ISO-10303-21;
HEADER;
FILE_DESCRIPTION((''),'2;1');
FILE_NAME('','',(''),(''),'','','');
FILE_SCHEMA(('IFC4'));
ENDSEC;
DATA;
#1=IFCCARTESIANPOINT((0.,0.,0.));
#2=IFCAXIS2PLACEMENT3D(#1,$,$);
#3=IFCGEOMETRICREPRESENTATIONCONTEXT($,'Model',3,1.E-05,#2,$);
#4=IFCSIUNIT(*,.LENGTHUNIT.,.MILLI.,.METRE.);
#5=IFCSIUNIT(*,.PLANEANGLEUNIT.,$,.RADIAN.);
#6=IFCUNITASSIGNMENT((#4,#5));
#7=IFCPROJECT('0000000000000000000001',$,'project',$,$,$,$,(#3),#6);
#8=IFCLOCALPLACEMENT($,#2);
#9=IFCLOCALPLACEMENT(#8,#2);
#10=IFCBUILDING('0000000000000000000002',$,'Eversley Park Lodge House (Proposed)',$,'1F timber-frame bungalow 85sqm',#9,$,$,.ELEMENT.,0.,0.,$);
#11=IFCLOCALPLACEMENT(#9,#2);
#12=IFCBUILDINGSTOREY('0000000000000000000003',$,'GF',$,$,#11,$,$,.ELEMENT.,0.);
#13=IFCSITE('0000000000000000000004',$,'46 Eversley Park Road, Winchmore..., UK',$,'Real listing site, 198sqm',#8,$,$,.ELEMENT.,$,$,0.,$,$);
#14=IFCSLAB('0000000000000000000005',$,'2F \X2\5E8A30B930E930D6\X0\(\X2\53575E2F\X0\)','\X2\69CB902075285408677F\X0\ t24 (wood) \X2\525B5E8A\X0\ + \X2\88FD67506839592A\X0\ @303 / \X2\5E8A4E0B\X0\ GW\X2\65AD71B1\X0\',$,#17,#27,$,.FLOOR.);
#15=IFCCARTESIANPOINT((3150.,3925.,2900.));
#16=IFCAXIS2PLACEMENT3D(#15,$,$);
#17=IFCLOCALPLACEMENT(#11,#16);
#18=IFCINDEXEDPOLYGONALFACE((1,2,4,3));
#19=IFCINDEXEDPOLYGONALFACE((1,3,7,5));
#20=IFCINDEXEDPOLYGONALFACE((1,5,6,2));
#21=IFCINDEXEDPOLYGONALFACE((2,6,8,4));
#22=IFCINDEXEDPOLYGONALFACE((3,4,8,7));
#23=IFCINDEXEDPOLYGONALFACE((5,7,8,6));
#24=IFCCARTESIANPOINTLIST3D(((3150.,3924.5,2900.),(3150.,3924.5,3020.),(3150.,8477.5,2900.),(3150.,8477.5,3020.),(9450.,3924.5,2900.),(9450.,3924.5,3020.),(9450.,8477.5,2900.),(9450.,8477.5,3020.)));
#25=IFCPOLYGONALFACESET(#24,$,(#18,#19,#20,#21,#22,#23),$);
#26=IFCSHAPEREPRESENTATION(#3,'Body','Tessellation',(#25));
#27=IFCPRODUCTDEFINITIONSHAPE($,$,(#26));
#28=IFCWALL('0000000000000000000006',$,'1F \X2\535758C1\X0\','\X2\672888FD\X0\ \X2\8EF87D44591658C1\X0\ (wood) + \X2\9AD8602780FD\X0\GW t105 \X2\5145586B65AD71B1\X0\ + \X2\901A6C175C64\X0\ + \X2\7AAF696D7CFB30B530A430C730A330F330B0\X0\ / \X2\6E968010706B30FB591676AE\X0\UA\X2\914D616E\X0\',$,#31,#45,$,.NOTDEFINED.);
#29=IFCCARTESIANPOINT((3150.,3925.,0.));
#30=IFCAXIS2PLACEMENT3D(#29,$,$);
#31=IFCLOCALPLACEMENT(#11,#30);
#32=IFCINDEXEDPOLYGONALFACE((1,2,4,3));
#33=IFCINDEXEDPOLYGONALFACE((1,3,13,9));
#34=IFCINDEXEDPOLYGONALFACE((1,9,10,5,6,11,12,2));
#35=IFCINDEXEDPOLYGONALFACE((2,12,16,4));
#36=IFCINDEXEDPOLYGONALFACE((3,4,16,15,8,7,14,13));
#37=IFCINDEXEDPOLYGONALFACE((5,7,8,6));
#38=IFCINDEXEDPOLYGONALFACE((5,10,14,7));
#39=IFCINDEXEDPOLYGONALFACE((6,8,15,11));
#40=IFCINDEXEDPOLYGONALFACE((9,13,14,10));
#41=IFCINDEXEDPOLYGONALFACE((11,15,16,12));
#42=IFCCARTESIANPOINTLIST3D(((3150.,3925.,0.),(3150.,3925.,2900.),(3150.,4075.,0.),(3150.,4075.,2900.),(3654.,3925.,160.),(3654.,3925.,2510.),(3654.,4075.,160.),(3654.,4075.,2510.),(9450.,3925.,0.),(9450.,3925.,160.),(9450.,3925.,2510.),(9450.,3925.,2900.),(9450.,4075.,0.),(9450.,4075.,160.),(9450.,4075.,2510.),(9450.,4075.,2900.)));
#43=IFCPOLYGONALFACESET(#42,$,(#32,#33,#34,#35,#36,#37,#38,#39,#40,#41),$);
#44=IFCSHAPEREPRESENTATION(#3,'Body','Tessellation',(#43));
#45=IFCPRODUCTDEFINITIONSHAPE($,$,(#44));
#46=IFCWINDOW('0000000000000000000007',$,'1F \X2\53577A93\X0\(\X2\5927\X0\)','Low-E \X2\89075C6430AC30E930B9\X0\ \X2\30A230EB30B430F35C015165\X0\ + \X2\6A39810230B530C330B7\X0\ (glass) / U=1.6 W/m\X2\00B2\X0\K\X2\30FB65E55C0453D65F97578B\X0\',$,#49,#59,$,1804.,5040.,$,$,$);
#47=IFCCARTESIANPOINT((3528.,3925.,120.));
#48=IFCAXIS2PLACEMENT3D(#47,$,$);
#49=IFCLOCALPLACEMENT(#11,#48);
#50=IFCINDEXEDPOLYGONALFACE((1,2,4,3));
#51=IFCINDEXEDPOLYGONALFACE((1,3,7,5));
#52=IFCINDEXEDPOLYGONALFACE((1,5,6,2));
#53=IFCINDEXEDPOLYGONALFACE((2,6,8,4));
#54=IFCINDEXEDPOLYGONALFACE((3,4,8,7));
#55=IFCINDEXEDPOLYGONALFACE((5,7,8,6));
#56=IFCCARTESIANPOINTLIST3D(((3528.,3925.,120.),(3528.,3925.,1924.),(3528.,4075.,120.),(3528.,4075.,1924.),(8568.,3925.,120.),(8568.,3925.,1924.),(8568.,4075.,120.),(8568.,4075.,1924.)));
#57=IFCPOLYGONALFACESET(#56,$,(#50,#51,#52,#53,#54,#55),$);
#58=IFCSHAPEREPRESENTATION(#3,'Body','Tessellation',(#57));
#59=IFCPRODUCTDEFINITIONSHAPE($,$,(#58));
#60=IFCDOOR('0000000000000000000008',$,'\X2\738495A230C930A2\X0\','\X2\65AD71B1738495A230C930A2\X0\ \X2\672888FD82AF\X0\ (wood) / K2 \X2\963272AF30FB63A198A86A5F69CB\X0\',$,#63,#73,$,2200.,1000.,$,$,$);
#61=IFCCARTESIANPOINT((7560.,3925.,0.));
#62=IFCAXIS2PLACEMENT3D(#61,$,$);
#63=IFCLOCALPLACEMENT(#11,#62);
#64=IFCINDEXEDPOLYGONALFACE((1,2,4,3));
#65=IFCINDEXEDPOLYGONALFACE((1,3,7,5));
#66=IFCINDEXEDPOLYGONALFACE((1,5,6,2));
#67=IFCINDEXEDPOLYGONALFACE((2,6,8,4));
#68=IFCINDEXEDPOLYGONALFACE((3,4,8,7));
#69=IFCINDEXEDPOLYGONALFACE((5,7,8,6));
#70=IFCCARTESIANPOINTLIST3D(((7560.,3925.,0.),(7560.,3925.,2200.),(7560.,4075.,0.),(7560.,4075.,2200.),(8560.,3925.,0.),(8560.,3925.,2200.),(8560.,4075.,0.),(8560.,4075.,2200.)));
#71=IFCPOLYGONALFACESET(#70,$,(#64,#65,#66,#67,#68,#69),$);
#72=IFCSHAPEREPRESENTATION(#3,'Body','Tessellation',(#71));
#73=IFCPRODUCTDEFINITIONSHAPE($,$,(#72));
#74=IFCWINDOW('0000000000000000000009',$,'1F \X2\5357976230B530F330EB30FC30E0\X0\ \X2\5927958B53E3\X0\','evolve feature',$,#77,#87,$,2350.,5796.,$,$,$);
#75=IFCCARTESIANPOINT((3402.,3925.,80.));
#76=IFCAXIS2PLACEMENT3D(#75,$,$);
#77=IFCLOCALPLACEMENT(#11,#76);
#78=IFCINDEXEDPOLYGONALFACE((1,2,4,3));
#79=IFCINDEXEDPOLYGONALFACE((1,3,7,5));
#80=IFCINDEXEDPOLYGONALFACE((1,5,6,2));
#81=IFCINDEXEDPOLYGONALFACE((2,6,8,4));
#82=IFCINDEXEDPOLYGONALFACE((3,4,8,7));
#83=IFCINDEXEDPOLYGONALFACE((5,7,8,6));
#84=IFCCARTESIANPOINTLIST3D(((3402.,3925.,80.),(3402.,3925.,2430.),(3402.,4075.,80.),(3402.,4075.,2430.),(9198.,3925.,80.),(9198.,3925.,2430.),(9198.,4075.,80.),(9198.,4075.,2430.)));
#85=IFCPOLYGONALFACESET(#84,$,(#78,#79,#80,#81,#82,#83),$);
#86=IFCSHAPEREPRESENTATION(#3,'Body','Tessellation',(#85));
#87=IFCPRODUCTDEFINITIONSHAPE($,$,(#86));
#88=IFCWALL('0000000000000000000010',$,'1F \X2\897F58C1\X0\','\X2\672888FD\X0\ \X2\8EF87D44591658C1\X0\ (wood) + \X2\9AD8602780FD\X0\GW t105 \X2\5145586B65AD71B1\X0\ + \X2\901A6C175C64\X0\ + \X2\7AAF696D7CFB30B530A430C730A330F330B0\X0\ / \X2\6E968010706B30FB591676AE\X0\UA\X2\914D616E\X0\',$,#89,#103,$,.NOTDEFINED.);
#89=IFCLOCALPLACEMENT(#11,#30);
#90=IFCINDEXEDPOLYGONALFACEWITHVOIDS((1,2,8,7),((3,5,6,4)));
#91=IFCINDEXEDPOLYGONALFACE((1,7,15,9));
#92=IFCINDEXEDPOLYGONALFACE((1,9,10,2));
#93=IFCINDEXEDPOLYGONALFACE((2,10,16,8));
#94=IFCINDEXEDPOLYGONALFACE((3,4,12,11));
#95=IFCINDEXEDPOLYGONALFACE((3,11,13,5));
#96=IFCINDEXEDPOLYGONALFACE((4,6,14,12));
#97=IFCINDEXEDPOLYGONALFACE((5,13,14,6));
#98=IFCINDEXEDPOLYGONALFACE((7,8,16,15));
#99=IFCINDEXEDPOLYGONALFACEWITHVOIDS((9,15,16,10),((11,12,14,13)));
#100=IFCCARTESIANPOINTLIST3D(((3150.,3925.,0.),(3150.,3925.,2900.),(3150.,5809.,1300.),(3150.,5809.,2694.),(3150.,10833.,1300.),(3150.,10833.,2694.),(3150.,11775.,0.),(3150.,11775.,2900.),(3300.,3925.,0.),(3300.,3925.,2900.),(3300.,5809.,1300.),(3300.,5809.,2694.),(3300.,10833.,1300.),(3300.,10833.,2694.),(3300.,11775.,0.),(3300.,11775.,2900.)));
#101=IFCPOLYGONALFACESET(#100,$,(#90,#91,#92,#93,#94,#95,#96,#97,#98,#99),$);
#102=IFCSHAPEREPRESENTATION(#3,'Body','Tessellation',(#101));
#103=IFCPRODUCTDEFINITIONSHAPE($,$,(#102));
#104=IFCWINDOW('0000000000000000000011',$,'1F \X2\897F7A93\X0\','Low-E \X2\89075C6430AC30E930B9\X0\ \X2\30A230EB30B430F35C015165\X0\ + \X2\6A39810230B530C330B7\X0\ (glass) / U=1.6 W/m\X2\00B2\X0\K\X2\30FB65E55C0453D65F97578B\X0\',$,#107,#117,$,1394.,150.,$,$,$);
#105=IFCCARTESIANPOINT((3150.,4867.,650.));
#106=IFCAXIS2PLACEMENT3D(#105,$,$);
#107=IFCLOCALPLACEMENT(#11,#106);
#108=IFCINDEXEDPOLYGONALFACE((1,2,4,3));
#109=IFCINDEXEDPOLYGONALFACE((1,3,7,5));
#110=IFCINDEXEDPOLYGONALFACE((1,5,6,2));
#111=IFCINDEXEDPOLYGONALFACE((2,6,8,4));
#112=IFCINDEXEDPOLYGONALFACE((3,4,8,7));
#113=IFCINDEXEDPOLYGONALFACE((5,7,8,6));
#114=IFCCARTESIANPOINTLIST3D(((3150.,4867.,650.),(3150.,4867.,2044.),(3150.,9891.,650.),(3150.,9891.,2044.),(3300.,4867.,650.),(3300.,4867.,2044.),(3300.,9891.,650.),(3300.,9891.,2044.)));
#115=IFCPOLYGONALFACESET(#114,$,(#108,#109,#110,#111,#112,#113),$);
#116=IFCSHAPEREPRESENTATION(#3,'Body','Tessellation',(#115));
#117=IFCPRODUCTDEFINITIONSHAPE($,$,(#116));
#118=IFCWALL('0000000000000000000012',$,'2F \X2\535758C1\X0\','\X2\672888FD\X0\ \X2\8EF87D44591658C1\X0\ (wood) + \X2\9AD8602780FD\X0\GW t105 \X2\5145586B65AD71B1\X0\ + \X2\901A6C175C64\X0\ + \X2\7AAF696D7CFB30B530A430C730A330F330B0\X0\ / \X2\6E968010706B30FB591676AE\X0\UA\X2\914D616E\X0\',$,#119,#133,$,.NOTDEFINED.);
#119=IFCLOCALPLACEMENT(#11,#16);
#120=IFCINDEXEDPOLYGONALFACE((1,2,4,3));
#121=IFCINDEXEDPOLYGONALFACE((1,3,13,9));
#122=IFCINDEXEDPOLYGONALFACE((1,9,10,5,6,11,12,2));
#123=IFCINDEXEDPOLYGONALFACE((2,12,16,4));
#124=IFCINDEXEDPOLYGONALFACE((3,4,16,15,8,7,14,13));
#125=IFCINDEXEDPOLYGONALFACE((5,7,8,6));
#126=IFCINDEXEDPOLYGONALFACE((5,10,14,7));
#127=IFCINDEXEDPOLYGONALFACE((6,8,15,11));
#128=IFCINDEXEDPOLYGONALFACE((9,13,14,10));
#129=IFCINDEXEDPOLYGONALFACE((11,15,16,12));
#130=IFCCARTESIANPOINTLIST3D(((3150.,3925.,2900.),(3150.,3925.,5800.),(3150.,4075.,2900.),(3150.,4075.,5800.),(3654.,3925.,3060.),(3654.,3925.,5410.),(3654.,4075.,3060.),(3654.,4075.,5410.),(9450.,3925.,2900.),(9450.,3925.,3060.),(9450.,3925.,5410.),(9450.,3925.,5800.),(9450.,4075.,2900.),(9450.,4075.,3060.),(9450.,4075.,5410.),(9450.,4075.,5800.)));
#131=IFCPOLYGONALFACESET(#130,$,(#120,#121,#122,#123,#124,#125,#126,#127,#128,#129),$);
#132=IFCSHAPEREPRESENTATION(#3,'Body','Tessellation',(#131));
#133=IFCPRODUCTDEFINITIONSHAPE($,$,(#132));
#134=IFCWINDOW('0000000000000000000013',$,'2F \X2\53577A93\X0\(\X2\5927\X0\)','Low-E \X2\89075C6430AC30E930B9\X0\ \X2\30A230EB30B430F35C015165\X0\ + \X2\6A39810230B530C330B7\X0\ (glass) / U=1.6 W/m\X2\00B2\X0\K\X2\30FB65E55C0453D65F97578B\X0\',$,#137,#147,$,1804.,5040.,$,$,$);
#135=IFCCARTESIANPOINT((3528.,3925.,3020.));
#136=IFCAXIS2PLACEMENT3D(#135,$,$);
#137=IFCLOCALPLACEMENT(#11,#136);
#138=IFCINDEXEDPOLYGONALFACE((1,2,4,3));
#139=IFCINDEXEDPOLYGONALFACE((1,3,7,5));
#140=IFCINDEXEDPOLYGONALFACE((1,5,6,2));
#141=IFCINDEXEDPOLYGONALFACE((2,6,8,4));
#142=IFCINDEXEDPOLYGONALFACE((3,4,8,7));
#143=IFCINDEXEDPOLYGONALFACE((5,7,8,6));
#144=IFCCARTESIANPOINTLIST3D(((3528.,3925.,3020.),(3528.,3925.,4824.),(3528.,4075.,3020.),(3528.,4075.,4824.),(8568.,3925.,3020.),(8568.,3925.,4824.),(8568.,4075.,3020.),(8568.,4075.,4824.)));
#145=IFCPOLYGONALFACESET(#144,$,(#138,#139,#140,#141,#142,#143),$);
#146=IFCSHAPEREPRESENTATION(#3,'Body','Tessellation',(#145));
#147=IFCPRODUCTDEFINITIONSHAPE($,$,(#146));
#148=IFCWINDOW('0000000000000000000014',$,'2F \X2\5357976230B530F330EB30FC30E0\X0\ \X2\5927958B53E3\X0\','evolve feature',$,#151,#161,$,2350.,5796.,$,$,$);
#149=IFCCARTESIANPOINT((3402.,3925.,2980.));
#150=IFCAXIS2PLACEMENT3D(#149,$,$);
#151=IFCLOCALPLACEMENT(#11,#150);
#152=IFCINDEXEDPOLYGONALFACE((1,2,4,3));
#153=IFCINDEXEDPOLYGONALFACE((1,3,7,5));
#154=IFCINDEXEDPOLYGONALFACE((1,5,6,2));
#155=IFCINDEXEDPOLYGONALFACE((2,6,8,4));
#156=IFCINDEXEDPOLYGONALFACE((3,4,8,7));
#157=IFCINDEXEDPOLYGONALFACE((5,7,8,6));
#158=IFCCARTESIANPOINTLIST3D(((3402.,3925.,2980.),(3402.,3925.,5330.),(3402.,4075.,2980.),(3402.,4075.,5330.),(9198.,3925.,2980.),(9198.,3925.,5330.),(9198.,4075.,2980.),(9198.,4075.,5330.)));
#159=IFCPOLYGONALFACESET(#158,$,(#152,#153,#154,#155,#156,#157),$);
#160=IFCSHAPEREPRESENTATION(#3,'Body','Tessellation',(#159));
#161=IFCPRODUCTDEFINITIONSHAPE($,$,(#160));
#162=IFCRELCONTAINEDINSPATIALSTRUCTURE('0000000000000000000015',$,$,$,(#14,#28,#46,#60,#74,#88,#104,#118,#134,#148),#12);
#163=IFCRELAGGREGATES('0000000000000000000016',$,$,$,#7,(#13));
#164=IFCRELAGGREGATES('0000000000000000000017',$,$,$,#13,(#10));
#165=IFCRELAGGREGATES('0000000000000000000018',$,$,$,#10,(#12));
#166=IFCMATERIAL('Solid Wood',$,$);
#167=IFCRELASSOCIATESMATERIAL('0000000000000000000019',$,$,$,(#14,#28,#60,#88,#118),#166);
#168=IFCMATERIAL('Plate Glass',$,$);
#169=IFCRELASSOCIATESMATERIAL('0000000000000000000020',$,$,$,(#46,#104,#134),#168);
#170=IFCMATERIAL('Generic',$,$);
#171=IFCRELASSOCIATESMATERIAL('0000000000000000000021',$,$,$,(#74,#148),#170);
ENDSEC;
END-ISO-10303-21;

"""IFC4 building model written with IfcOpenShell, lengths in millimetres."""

from ifc_helpers import new_model, si_unit, frame, frame_2d, origin, place, context, project, spatial, rectangle, extrude, material, element, fill, save


model = new_model("IFC4")

# Units and contexts
model_context = context("Model", 3, precision=1e-05, world=origin())
ifc_project = project(units=[si_unit("LENGTHUNIT", "METRE", prefix="MILLI"), si_unit("PLANEANGLEUNIT", "RADIAN")], contexts=[model_context])

# Site, building, storey
site_placement = place(None, origin())
site = spatial("IfcSite", under=ifc_project, at=site_placement, Name="46 Eversley Park Road, Winchmore..., UK", ObjectType="Real listing site, 198sqm", CompositionType="ELEMENT", RefElevation=0.0)
building_placement = place(site_placement, origin())
building = spatial("IfcBuilding", under=site, at=building_placement, Name="Eversley Park Lodge House (Proposed)", ObjectType="1F timber-frame bungalow 85sqm", CompositionType="ELEMENT", ElevationOfRefHeight=0.0, ElevationOfTerrain=0.0)
storey_placement = place(building_placement, origin())
storey = spatial("IfcBuildingStorey", under=building, at=storey_placement, Name="GF", CompositionType="ELEMENT", Elevation=0.0)

# Slab
ifc_material_1 = material(Name="Solid Wood")
slab_1_placement = place(storey_placement, frame((3150.0, 3925.0, 2900.0)))
element("IfcSlab", 1, at=slab_1_placement, inside=storey, material=ifc_material_1, Name="2F 床スラブ(南帯)", Description="構造用合板 t24 (wood) 剛床 + 製材根太 @303 / 床下 GW断熱", PredefinedType="FLOOR", context=model_context, shape_type="SweptSolid", body=[
    extrude(rectangle(XDim=6300.0, YDim=4553.0, at=frame_2d((3150.0, 2276.0))), frame((3150.0, 3925.0, 2900.0)), (0.0, 0.0, 1.0), 120.0),
])
ifc_material_2 = material(Name="Generic")

# Wall, openings, windows, door
wall_1_placement = place(storey_placement, frame((3150.0, 3925.0, 0.0)))
wall_1 = element("IfcWall", 2, at=wall_1_placement, inside=storey, material=ifc_material_1, Name="1F 南壁", Description="木製 軸組外壁 (wood) + 高性能GW t105 充填断熱 + 通気層 + 窯業系サイディング / 準耐火・外皮UA配慮", PredefinedType="NOTDEFINED", context=model_context, shape_type="SweptSolid", body=[
    extrude(rectangle(XDim=6300.0, YDim=150.0, at=frame_2d((3150.0, 75.0))), frame((3150.0, 3925.0, 0.0)), (0.0, 0.0, 1.0), 2900.0),
])
opening_1_placement = place(storey_placement, frame((3528.0, 3925.0, 120.0)))
opening_1 = element("IfcOpeningElement", 3, at=opening_1_placement, cuts=wall_1, PredefinedType="NOTDEFINED", context=model_context, shape_type="SweptSolid", body=[
    extrude(rectangle(XDim=5040.0, YDim=150.0, at=frame_2d((2520.0, 75.0))), frame((3528.0, 3925.0, 120.0)), (0.0, 0.0, 1.0), 1804.0),
])
opening_2_placement = place(storey_placement, frame((7560.0, 3925.0, 0.0)))
opening_2 = element("IfcOpeningElement", 4, at=opening_2_placement, cuts=wall_1, PredefinedType="NOTDEFINED", context=model_context, shape_type="SweptSolid", body=[
    extrude(rectangle(XDim=1000.0, YDim=150.0, at=frame_2d((500.0, 75.0))), frame((7560.0, 3925.0, 0.0)), (0.0, 0.0, 1.0), 2200.0),
])
opening_3_placement = place(storey_placement, frame((3402.0, 3925.0, 80.0)))
opening_3 = element("IfcOpeningElement", 5, at=opening_3_placement, cuts=wall_1, PredefinedType="NOTDEFINED", context=model_context, shape_type="SweptSolid", body=[
    extrude(rectangle(XDim=5796.0, YDim=150.0, at=frame_2d((2898.0, 75.0))), frame((3402.0, 3925.0, 80.0)), (0.0, 0.0, 1.0), 2350.0),
])
ifc_material_3 = material(Name="Plate Glass")
window_1_placement = place(storey_placement, frame((3528.0, 3925.0, 120.0)))
window_1 = element("IfcWindow", 6, at=window_1_placement, inside=storey, material=ifc_material_3, Name="1F 南窓(大)", Description="Low-E 複層ガラス アルゴン封入 + 樹脂サッシ (glass) / U=1.6 W/m²K・日射取得型", OverallHeight=1804.0, OverallWidth=5040.0, context=model_context, shape_type="SweptSolid", body=[
    extrude(rectangle(XDim=5040.0, YDim=150.0, at=frame_2d((2520.0, 75.0))), frame((3528.0, 3925.0, 120.0)), (0.0, 0.0, 1.0), 1804.0),
])
fill(opening_1, window_1)
door_placement = place(storey_placement, frame((7560.0, 3925.0, 0.0)))
door = element("IfcDoor", 7, at=door_placement, inside=storey, material=ifc_material_1, Name="玄関ドア", Description="断熱玄関ドア 木製芯 (wood) / K2 防犯・採風機構", OverallHeight=2200.0, OverallWidth=1000.0, context=model_context, shape_type="SweptSolid", body=[
    extrude(rectangle(XDim=1000.0, YDim=150.0, at=frame_2d((500.0, 75.0))), frame((7560.0, 3925.0, 0.0)), (0.0, 0.0, 1.0), 2200.0),
])
fill(opening_2, door)
window_2_placement = place(storey_placement, frame((3402.0, 3925.0, 80.0)))
window_2 = element("IfcWindow", 8, at=window_2_placement, inside=storey, material=ifc_material_2, Name="1F 南面サンルーム 大開口", Description="evolve feature", OverallHeight=2350.0, OverallWidth=5796.0, context=model_context, shape_type="SweptSolid", body=[
    extrude(rectangle(XDim=5796.0, YDim=150.0, at=frame_2d((2898.0, 75.0))), frame((3402.0, 3925.0, 80.0)), (0.0, 0.0, 1.0), 2350.0),
])
fill(opening_3, window_2)

# Wall, opening, window
wall_2_placement = place(storey_placement, frame((3150.0, 3925.0, 0.0)))
wall_2 = element("IfcWall", 9, at=wall_2_placement, inside=storey, material=ifc_material_1, Name="1F 西壁", Description="木製 軸組外壁 (wood) + 高性能GW t105 充填断熱 + 通気層 + 窯業系サイディング / 準耐火・外皮UA配慮", PredefinedType="NOTDEFINED", context=model_context, shape_type="SweptSolid", body=[
    extrude(rectangle(XDim=150.0, YDim=7850.0, at=frame_2d((75.0, 3925.0))), frame((3150.0, 3925.0, 0.0)), (0.0, 0.0, 1.0), 2900.0),
])
opening_4_placement = place(storey_placement, frame((3150.0, 4867.0, 650.0)))
opening_4 = element("IfcOpeningElement", 10, at=opening_4_placement, cuts=wall_2, PredefinedType="NOTDEFINED", context=model_context, shape_type="SweptSolid", body=[
    extrude(rectangle(XDim=150.0, YDim=5024.0, at=frame_2d((75.0, 2512.0))), frame((3150.0, 4867.0, 650.0)), (0.0, 0.0, 1.0), 1394.0),
])
window_3_placement = place(storey_placement, frame((3150.0, 4867.0, 650.0)))
window_3 = element("IfcWindow", 11, at=window_3_placement, inside=storey, material=ifc_material_3, Name="1F 西窓", Description="Low-E 複層ガラス アルゴン封入 + 樹脂サッシ (glass) / U=1.6 W/m²K・日射取得型", OverallHeight=1394.0, OverallWidth=150.0, context=model_context, shape_type="SweptSolid", body=[
    extrude(rectangle(XDim=150.0, YDim=5024.0, at=frame_2d((75.0, 2512.0))), frame((3150.0, 4867.0, 650.0)), (0.0, 0.0, 1.0), 1394.0),
])
fill(opening_4, window_3)

# Wall, openings, windows
wall_3_placement = place(storey_placement, frame((3150.0, 3925.0, 2900.0)))
wall_3 = element("IfcWall", 12, at=wall_3_placement, inside=storey, material=ifc_material_1, Name="2F 南壁", Description="木製 軸組外壁 (wood) + 高性能GW t105 充填断熱 + 通気層 + 窯業系サイディング / 準耐火・外皮UA配慮", PredefinedType="NOTDEFINED", context=model_context, shape_type="SweptSolid", body=[
    extrude(rectangle(XDim=6300.0, YDim=150.0, at=frame_2d((3150.0, 75.0))), frame((3150.0, 3925.0, 2900.0)), (0.0, 0.0, 1.0), 2900.0),
])
opening_5_placement = place(storey_placement, frame((3528.0, 3925.0, 3020.0)))
opening_5 = element("IfcOpeningElement", 13, at=opening_5_placement, cuts=wall_3, PredefinedType="NOTDEFINED", context=model_context, shape_type="SweptSolid", body=[
    extrude(rectangle(XDim=5040.0, YDim=150.0, at=frame_2d((2520.0, 75.0))), frame((3528.0, 3925.0, 3020.0)), (0.0, 0.0, 1.0), 1804.0),
])
opening_6_placement = place(storey_placement, frame((3402.0, 3925.0, 2980.0)))
opening_6 = element("IfcOpeningElement", 14, at=opening_6_placement, cuts=wall_3, PredefinedType="NOTDEFINED", context=model_context, shape_type="SweptSolid", body=[
    extrude(rectangle(XDim=5796.0, YDim=150.0, at=frame_2d((2898.0, 75.0))), frame((3402.0, 3925.0, 2980.0)), (0.0, 0.0, 1.0), 2350.0),
])
window_4_placement = place(storey_placement, frame((3528.0, 3925.0, 3020.0)))
window_4 = element("IfcWindow", 15, at=window_4_placement, inside=storey, material=ifc_material_3, Name="2F 南窓(大)", Description="Low-E 複層ガラス アルゴン封入 + 樹脂サッシ (glass) / U=1.6 W/m²K・日射取得型", OverallHeight=1804.0, OverallWidth=5040.0, context=model_context, shape_type="SweptSolid", body=[
    extrude(rectangle(XDim=5040.0, YDim=150.0, at=frame_2d((2520.0, 75.0))), frame((3528.0, 3925.0, 3020.0)), (0.0, 0.0, 1.0), 1804.0),
])
fill(opening_5, window_4)
window_5_placement = place(storey_placement, frame((3402.0, 3925.0, 2980.0)))
window_5 = element("IfcWindow", 16, at=window_5_placement, inside=storey, material=ifc_material_2, Name="2F 南面サンルーム 大開口", Description="evolve feature", OverallHeight=2350.0, OverallWidth=5796.0, context=model_context, shape_type="SweptSolid", body=[
    extrude(rectangle(XDim=5796.0, YDim=150.0, at=frame_2d((2898.0, 75.0))), frame((3402.0, 3925.0, 2980.0)), (0.0, 0.0, 1.0), 2350.0),
])
fill(opening_6, window_5)

save(model, "model.ifc")
